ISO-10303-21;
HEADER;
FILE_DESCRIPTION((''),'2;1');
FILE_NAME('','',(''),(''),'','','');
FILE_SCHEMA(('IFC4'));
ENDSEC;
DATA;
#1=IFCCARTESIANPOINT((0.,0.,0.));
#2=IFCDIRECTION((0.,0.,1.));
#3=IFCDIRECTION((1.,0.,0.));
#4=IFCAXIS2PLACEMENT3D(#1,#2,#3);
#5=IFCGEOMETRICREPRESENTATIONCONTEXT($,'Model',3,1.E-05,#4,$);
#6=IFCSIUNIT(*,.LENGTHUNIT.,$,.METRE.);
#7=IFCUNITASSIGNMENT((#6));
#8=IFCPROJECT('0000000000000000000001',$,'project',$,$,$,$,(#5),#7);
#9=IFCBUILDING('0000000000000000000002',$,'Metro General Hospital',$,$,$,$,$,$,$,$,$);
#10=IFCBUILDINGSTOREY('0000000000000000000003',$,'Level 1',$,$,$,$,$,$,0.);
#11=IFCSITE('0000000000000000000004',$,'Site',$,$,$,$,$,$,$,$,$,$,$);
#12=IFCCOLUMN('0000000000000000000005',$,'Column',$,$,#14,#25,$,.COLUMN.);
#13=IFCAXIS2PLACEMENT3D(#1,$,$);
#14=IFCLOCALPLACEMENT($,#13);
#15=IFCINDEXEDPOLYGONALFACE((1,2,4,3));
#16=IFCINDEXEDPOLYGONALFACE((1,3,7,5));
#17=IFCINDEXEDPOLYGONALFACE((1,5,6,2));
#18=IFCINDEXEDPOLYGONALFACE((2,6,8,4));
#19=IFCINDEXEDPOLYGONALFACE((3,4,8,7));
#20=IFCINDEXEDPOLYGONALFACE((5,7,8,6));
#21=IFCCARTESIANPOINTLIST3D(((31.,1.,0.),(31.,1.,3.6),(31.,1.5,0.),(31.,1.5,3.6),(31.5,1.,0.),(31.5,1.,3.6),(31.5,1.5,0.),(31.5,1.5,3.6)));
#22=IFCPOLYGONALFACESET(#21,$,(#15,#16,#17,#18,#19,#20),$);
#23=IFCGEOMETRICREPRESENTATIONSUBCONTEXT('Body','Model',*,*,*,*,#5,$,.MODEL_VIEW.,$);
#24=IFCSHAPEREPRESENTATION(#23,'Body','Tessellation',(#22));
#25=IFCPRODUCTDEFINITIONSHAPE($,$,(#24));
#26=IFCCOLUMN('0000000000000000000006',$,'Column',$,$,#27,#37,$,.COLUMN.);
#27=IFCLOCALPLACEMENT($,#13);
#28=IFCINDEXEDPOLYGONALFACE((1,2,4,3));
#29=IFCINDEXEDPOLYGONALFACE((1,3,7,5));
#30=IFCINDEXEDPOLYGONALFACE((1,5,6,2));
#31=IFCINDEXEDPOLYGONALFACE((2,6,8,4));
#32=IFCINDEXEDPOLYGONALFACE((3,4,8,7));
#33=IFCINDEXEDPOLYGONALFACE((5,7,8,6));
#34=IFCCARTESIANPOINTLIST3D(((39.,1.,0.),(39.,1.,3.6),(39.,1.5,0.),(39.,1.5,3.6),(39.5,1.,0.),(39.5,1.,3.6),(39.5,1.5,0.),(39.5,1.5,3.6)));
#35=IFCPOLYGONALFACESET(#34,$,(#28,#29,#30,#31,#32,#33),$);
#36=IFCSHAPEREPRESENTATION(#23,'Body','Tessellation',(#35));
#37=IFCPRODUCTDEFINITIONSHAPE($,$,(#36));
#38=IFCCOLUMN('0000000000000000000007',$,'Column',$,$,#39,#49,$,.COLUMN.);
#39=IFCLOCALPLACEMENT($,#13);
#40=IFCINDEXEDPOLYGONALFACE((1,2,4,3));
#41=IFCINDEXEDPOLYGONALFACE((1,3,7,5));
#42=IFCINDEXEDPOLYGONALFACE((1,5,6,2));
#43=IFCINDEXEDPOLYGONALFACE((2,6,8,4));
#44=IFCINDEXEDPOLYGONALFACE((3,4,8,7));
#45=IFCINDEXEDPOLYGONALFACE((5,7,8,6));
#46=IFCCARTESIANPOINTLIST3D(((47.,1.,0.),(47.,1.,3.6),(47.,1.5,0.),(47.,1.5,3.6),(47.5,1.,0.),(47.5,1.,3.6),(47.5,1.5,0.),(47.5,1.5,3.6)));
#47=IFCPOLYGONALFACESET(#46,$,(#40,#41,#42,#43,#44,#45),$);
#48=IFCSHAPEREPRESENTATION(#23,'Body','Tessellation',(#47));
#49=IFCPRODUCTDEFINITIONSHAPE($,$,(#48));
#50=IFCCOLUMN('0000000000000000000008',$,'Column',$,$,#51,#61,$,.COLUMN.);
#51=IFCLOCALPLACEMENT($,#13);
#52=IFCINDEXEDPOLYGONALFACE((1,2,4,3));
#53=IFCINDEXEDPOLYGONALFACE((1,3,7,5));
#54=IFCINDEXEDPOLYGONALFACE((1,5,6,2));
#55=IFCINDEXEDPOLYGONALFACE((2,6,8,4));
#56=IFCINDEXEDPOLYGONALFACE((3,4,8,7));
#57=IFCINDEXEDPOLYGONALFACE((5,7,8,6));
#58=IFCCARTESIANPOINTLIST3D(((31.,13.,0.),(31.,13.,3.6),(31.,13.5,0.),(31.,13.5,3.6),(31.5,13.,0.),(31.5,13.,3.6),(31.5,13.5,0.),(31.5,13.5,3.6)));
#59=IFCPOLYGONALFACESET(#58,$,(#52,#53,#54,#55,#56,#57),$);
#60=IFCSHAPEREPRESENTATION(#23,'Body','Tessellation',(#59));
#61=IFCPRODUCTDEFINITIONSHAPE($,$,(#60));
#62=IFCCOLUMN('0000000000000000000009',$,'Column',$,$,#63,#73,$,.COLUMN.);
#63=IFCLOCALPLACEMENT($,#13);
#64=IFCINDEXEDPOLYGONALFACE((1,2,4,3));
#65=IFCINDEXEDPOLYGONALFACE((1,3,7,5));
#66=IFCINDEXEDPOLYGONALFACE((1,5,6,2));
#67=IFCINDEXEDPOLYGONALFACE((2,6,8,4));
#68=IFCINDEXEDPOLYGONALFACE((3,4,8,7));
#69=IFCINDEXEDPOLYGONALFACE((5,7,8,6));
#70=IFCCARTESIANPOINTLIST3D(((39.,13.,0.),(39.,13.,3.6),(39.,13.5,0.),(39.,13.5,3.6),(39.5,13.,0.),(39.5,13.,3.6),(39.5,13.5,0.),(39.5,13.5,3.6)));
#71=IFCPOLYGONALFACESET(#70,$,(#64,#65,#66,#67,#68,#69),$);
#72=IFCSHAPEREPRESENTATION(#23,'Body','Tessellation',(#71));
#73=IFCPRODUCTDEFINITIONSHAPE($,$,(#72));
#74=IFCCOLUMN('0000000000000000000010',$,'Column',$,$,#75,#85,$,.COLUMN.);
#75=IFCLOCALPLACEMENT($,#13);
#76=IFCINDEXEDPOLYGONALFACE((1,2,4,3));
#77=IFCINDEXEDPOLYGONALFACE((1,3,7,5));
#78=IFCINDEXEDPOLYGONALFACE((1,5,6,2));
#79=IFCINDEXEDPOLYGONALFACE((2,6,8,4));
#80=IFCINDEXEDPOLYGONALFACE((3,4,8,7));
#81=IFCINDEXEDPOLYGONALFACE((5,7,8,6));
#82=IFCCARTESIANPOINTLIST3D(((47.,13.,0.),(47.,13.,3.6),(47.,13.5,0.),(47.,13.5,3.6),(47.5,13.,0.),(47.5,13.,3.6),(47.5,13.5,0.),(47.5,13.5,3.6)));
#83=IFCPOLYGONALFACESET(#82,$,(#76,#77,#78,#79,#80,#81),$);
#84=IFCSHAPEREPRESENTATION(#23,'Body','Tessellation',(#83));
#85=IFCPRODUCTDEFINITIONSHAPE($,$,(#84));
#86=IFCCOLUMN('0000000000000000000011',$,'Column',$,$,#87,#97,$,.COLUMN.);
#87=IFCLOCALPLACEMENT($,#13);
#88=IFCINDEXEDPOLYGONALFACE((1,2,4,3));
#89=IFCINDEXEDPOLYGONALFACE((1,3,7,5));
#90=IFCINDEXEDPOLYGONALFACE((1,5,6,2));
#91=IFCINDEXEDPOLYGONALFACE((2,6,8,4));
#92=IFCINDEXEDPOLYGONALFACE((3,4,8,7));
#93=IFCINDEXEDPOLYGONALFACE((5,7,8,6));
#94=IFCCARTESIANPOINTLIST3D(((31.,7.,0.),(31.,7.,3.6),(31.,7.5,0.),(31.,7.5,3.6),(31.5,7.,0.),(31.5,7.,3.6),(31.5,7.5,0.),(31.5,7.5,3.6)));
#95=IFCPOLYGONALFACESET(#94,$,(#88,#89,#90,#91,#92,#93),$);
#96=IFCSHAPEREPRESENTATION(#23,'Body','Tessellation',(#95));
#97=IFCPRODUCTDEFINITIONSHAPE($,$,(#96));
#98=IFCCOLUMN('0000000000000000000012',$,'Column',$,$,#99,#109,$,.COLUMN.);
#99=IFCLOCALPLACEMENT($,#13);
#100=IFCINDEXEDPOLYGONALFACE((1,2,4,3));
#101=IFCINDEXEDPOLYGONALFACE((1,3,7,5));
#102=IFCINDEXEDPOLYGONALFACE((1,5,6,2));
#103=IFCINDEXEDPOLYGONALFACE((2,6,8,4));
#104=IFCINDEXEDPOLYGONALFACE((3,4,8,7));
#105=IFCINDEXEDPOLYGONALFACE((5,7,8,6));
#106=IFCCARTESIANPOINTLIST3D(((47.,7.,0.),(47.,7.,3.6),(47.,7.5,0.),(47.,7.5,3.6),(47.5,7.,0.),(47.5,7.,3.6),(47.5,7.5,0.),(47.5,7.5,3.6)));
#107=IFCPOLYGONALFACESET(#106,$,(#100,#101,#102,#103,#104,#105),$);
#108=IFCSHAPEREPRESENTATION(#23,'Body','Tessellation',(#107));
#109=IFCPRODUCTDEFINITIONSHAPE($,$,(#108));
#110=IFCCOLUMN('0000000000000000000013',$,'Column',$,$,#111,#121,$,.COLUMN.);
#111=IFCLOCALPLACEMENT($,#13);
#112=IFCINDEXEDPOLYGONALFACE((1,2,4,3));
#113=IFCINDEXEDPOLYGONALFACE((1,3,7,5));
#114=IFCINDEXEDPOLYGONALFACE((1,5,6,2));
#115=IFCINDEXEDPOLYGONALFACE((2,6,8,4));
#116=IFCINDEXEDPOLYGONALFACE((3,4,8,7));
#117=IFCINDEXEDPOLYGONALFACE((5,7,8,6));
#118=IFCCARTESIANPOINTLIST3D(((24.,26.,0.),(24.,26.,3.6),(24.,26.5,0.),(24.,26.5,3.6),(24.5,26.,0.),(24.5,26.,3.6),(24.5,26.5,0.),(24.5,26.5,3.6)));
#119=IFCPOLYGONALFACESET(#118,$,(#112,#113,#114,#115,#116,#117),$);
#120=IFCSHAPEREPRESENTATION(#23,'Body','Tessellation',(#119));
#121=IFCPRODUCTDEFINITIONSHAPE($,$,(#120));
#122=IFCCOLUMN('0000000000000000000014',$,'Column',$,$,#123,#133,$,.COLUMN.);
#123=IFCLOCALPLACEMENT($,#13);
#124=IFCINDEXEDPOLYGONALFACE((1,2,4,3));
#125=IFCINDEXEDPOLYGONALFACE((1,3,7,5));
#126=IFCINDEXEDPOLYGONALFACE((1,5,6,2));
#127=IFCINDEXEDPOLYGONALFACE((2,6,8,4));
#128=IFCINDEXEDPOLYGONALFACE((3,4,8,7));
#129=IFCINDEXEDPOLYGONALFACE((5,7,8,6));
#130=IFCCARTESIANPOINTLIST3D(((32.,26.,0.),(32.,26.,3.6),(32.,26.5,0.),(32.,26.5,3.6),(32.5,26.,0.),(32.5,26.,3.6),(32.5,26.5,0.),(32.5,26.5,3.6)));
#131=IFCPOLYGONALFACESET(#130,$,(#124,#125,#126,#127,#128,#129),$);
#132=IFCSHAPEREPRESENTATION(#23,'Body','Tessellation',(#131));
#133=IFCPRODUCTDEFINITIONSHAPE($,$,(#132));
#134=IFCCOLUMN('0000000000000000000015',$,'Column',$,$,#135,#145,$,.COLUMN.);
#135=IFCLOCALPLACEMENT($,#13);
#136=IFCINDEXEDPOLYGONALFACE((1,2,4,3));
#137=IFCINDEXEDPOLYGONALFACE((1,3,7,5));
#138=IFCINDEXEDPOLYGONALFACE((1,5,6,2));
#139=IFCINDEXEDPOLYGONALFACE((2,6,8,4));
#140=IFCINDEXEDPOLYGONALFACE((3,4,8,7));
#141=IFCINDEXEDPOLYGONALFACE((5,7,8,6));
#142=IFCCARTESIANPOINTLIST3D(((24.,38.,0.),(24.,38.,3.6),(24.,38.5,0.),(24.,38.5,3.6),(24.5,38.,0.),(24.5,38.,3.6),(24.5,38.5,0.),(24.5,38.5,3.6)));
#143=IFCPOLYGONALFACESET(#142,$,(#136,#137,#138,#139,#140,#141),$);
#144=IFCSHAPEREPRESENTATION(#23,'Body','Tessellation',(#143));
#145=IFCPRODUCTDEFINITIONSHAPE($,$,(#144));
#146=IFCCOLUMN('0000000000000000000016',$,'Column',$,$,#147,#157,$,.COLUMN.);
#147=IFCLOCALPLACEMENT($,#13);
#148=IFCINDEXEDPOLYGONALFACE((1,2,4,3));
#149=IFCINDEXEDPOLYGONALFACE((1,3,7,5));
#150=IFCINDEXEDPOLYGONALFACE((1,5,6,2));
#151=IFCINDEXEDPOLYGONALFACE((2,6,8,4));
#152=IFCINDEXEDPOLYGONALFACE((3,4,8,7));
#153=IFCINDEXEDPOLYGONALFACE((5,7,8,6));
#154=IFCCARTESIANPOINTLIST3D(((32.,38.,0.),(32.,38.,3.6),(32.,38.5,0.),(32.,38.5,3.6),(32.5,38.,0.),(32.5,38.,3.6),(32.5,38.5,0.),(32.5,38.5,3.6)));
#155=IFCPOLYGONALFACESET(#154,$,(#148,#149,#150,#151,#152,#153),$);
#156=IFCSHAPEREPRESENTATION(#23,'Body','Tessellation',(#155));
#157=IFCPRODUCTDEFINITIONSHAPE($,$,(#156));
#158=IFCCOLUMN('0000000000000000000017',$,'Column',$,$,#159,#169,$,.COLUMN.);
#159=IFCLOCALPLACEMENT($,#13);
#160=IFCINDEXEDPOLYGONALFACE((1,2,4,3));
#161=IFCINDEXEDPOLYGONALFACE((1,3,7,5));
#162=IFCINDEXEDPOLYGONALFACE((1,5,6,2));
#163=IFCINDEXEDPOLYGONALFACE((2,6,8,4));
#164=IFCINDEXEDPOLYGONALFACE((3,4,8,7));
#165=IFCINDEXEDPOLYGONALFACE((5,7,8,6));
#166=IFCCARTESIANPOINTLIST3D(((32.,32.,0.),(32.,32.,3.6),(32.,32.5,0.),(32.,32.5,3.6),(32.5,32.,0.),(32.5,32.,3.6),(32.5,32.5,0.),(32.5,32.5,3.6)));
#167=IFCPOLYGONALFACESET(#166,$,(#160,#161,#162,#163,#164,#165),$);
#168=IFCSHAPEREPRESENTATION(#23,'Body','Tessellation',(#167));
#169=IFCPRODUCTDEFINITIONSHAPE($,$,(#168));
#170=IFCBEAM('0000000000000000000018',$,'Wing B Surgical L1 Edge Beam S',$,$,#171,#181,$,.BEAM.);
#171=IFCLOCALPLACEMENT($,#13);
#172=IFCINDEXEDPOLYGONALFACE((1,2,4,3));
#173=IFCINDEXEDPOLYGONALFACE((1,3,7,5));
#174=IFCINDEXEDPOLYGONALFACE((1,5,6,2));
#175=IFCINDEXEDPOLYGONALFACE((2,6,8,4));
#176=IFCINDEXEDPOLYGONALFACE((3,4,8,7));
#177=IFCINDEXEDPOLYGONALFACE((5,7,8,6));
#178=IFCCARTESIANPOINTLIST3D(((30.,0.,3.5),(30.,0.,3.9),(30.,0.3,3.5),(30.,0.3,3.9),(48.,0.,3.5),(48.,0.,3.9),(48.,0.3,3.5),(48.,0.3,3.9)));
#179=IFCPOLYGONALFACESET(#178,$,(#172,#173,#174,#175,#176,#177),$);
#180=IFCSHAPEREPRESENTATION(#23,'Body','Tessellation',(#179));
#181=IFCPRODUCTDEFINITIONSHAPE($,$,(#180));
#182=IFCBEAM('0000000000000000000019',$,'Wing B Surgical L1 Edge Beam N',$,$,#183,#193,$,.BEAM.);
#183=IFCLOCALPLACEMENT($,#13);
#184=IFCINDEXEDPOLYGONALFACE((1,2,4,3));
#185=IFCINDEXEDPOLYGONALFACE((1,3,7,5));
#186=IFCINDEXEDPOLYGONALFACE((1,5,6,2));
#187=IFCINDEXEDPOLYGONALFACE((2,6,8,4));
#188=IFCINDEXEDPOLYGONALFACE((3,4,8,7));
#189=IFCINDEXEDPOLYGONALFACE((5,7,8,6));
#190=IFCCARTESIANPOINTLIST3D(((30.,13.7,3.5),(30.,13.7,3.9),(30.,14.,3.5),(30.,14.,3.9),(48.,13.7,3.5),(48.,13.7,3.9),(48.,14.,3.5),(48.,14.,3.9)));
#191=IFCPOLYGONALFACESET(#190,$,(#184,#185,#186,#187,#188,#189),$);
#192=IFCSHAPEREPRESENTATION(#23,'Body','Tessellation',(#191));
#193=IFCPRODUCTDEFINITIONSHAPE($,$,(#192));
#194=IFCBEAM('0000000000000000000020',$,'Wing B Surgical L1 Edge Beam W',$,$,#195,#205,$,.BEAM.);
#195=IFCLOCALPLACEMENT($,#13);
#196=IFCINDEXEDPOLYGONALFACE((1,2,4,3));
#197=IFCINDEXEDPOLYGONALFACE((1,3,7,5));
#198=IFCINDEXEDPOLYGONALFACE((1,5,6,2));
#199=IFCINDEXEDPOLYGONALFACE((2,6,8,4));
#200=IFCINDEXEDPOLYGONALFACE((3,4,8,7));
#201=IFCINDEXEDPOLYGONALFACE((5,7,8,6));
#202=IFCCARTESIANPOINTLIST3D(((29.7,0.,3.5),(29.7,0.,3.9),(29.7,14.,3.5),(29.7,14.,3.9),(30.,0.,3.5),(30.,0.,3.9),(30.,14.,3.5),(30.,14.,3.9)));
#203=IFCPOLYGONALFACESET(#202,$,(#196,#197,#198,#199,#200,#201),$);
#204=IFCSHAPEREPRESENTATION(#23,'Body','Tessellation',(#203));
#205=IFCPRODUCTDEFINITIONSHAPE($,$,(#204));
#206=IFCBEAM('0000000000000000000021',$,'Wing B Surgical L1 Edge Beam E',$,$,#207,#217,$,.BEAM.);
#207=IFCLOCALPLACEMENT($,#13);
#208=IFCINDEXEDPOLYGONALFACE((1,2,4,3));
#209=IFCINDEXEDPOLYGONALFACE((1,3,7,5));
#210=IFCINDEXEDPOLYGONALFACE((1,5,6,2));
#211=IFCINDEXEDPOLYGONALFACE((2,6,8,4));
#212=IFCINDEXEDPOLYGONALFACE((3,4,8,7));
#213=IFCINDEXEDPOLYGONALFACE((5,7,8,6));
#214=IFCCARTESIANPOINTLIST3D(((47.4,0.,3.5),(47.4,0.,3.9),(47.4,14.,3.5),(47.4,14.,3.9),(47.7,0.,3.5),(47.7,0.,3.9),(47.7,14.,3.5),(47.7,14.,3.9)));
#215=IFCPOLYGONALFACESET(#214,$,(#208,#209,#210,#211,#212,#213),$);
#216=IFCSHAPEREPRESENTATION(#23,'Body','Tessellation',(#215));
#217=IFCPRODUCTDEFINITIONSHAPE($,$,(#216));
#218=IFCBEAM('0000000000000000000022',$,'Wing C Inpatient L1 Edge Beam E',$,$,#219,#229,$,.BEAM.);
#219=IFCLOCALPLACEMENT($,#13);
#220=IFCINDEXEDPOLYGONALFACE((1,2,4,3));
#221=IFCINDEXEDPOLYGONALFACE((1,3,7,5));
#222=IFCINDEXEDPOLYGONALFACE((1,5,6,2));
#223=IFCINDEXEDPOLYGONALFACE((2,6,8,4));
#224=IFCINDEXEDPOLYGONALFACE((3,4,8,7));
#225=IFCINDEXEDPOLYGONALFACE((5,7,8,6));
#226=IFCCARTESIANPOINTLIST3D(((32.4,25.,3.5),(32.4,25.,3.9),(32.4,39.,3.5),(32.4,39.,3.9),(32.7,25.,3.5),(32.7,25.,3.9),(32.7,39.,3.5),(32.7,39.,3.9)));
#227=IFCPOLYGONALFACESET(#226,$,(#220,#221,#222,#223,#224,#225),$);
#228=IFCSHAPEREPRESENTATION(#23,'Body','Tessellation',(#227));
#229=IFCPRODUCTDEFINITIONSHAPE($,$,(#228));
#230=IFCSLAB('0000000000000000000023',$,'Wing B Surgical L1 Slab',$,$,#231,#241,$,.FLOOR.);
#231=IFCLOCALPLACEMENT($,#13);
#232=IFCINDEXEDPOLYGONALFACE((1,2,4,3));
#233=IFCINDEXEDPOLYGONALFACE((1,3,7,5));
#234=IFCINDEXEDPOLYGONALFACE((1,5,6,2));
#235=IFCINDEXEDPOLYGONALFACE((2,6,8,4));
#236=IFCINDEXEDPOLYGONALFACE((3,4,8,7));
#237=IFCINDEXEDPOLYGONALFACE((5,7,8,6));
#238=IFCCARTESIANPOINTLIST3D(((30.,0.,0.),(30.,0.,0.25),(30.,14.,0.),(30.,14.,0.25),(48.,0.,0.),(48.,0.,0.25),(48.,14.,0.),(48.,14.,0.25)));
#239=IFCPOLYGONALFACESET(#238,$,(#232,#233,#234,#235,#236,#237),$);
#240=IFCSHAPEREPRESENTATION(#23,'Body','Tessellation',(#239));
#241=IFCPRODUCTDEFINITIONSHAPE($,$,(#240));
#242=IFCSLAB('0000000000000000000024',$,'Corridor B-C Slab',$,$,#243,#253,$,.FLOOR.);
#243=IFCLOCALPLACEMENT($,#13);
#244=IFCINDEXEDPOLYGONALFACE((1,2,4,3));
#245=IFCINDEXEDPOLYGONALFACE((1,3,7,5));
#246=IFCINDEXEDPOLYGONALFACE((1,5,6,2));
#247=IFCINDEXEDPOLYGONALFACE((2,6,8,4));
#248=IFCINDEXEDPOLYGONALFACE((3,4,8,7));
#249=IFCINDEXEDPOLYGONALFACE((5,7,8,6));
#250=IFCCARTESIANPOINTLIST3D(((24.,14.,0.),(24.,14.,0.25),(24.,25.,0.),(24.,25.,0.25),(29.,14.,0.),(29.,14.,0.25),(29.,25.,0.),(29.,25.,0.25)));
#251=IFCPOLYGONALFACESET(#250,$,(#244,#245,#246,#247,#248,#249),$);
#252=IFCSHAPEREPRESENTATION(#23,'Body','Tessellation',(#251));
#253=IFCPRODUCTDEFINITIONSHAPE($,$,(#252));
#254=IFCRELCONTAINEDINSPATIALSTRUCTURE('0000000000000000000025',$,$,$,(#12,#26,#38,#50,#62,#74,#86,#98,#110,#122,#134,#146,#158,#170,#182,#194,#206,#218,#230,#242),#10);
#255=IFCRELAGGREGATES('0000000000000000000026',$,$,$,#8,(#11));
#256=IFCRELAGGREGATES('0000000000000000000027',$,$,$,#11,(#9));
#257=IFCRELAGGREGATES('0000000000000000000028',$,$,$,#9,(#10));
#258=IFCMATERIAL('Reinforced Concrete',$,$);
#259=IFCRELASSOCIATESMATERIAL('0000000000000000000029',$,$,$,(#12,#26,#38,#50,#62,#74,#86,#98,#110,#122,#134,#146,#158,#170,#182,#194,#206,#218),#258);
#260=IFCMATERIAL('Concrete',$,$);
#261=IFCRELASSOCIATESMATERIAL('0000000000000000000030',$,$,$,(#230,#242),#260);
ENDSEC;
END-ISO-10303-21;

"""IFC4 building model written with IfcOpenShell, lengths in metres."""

from ifc_helpers import new_model, si_unit, frame, origin_with_axes, place, context, subcontext, project, spatial, line, indexed_curve, outline, extrude, material, element, save


model = new_model("IFC4")

# Units and contexts
model_context = context("Model", 3, precision=1e-05, world=origin_with_axes())
body_context = subcontext(model_context, "Body", "Model", "MODEL_VIEW")
ifc_project = project(units=[si_unit("LENGTHUNIT", "METRE")], contexts=[model_context])

# Site, building, storey
site = spatial("IfcSite", under=ifc_project, Name="Site")
building = spatial("IfcBuilding", under=site, Name="Metro General Hospital")
storey = spatial("IfcBuildingStorey", under=building, Name="Level 1", Elevation=0.0)

# Columns
ifc_material_1 = material(Name="Reinforced Concrete")
for number, where, z_axis, x_axis, name in (
    (1, (31.0, 1.0, 0.0), (0.0, 0.0, 1.0), (1.0, 0.0, 0.0), "Column"),
    (2, (39.0, 1.0, 0.0), (0.0, 0.0, 1.0), (1.0, 0.0, 0.0), "Column"),
    (3, (47.0, 1.0, 0.0), (0.0, 0.0, 1.0), (1.0, 0.0, 0.0), "Column"),
    (4, (31.0, 13.0, 0.0), (0.0, 0.0, 1.0), (1.0, 0.0, 0.0), "Column"),
    (5, (39.0, 13.0, 0.0), (0.0, 0.0, 1.0), (1.0, 0.0, 0.0), "Column"),
    (6, (47.0, 13.0, 0.0), (0.0, 0.0, 1.0), (1.0, 0.0, 0.0), "Column"),
    (7, (31.0, 7.0, 0.0), (0.0, 0.0, 1.0), (1.0, 0.0, 0.0), "Column"),
    (8, (47.0, 7.0, 0.0), (0.0, 0.0, 1.0), (1.0, 0.0, 0.0), "Column"),
    (9, (24.0, 26.0, 0.0), (0.0, 0.0, 1.0), (1.0, 0.0, 0.0), "Column"),
    (10, (32.0, 26.0, 0.0), (0.0, 0.0, 1.0), (1.0, 0.0, 0.0), "Column"),
    (11, (24.0, 38.0, 0.0), (0.0, 0.0, 1.0), (1.0, 0.0, 0.0), "Column"),
    (12, (32.0, 38.0, 0.0), (0.0, 0.0, 1.0), (1.0, 0.0, 0.0), "Column"),
    (13, (32.0, 32.0, 0.0), (0.0, 0.0, 1.0), (1.0, 0.0, 0.0), "Column"),
):
    element("IfcColumn", number, at=place(None, frame(where, z_axis=z_axis, x_axis=x_axis)), inside=storey, material=ifc_material_1, Name=name, PredefinedType="COLUMN", context=body_context, shape_type="SweptSolid", body=[
        extrude(outline(indexed_curve([(0.0, 0.0), (0.5, 0.0), (0.5, 0.5), (0.0, 0.5)], segments=[line(1, 2, 3, 4, 1)])), origin_with_axes(), (0.0, 0.0, 1.0), 3.6),
    ])

# Beams
for number, where, z_axis, x_axis, name in (
    (14, (30.0, 0.0, 3.5), (0.0, 0.0, 1.0), (1.0, 0.0, 0.0), "Wing B Surgical L1 Edge Beam S"),
    (15, (30.0, 13.7, 3.5), (0.0, 0.0, 1.0), (1.0, 0.0, 0.0), "Wing B Surgical L1 Edge Beam N"),
):
    element("IfcBeam", number, at=place(None, frame(where, z_axis=z_axis, x_axis=x_axis)), inside=storey, material=ifc_material_1, Name=name, PredefinedType="BEAM", context=body_context, shape_type="SweptSolid", body=[
        extrude(outline(indexed_curve([(0.0, 0.0), (18.0, 0.0), (18.0, 0.3), (0.0, 0.3)], segments=[line(1, 2, 3, 4, 1)])), origin_with_axes(), (0.0, 0.0, 1.0), 0.4),
    ])
for number, where, z_axis, x_axis, name in (
    (16, (30.0, 0.0, 3.5), (0.0, 0.0, 1.0), (0.0, 1.0, 0.0), "Wing B Surgical L1 Edge Beam W"),
    (17, (47.7, 0.0, 3.5), (0.0, 0.0, 1.0), (0.0, 1.0, 0.0), "Wing B Surgical L1 Edge Beam E"),
    (18, (32.7, 25.0, 3.5), (0.0, 0.0, 1.0), (0.0, 1.0, 0.0), "Wing C Inpatient L1 Edge Beam E"),
):
    element("IfcBeam", number, at=place(None, frame(where, z_axis=z_axis, x_axis=x_axis)), inside=storey, material=ifc_material_1, Name=name, PredefinedType="BEAM", context=body_context, shape_type="SweptSolid", body=[
        extrude(outline(indexed_curve([(0.0, 0.0), (14.0, 0.0), (14.0, 0.3), (0.0, 0.3)], segments=[line(1, 2, 3, 4, 1)])), origin_with_axes(), (0.0, 0.0, 1.0), 0.4),
    ])

# Slabs
ifc_material_2 = material(Name="Concrete")
slab_1_placement = place(None, frame((30.0, 0.0, 0.0), z_axis=(0.0, 0.0, 1.0), x_axis=(1.0, 0.0, 0.0)))
element("IfcSlab", 19, at=slab_1_placement, inside=storey, material=ifc_material_2, Name="Wing B Surgical L1 Slab", PredefinedType="FLOOR", context=body_context, shape_type="SweptSolid", body=[
    extrude(outline(indexed_curve([(0.0, 0.0), (18.0, 0.0), (18.0, 14.0), (0.0, 14.0)], segments=[line(1, 2, 3, 4, 1)])), origin_with_axes(), (0.0, 0.0, 1.0), 0.25),
])
slab_2_placement = place(None, frame((24.0, 14.0, 0.0), z_axis=(0.0, 0.0, 1.0), x_axis=(1.0, 0.0, 0.0)))
element("IfcSlab", 20, at=slab_2_placement, inside=storey, material=ifc_material_2, Name="Corridor B-C Slab", PredefinedType="FLOOR", context=body_context, shape_type="SweptSolid", body=[
    extrude(outline(indexed_curve([(0.0, 0.0), (5.0, 0.0), (5.0, 11.0), (0.0, 11.0)], segments=[line(1, 2, 3, 4, 1)])), origin_with_axes(), (0.0, 0.0, 1.0), 0.25),
])

save(model, "model.ifc")
